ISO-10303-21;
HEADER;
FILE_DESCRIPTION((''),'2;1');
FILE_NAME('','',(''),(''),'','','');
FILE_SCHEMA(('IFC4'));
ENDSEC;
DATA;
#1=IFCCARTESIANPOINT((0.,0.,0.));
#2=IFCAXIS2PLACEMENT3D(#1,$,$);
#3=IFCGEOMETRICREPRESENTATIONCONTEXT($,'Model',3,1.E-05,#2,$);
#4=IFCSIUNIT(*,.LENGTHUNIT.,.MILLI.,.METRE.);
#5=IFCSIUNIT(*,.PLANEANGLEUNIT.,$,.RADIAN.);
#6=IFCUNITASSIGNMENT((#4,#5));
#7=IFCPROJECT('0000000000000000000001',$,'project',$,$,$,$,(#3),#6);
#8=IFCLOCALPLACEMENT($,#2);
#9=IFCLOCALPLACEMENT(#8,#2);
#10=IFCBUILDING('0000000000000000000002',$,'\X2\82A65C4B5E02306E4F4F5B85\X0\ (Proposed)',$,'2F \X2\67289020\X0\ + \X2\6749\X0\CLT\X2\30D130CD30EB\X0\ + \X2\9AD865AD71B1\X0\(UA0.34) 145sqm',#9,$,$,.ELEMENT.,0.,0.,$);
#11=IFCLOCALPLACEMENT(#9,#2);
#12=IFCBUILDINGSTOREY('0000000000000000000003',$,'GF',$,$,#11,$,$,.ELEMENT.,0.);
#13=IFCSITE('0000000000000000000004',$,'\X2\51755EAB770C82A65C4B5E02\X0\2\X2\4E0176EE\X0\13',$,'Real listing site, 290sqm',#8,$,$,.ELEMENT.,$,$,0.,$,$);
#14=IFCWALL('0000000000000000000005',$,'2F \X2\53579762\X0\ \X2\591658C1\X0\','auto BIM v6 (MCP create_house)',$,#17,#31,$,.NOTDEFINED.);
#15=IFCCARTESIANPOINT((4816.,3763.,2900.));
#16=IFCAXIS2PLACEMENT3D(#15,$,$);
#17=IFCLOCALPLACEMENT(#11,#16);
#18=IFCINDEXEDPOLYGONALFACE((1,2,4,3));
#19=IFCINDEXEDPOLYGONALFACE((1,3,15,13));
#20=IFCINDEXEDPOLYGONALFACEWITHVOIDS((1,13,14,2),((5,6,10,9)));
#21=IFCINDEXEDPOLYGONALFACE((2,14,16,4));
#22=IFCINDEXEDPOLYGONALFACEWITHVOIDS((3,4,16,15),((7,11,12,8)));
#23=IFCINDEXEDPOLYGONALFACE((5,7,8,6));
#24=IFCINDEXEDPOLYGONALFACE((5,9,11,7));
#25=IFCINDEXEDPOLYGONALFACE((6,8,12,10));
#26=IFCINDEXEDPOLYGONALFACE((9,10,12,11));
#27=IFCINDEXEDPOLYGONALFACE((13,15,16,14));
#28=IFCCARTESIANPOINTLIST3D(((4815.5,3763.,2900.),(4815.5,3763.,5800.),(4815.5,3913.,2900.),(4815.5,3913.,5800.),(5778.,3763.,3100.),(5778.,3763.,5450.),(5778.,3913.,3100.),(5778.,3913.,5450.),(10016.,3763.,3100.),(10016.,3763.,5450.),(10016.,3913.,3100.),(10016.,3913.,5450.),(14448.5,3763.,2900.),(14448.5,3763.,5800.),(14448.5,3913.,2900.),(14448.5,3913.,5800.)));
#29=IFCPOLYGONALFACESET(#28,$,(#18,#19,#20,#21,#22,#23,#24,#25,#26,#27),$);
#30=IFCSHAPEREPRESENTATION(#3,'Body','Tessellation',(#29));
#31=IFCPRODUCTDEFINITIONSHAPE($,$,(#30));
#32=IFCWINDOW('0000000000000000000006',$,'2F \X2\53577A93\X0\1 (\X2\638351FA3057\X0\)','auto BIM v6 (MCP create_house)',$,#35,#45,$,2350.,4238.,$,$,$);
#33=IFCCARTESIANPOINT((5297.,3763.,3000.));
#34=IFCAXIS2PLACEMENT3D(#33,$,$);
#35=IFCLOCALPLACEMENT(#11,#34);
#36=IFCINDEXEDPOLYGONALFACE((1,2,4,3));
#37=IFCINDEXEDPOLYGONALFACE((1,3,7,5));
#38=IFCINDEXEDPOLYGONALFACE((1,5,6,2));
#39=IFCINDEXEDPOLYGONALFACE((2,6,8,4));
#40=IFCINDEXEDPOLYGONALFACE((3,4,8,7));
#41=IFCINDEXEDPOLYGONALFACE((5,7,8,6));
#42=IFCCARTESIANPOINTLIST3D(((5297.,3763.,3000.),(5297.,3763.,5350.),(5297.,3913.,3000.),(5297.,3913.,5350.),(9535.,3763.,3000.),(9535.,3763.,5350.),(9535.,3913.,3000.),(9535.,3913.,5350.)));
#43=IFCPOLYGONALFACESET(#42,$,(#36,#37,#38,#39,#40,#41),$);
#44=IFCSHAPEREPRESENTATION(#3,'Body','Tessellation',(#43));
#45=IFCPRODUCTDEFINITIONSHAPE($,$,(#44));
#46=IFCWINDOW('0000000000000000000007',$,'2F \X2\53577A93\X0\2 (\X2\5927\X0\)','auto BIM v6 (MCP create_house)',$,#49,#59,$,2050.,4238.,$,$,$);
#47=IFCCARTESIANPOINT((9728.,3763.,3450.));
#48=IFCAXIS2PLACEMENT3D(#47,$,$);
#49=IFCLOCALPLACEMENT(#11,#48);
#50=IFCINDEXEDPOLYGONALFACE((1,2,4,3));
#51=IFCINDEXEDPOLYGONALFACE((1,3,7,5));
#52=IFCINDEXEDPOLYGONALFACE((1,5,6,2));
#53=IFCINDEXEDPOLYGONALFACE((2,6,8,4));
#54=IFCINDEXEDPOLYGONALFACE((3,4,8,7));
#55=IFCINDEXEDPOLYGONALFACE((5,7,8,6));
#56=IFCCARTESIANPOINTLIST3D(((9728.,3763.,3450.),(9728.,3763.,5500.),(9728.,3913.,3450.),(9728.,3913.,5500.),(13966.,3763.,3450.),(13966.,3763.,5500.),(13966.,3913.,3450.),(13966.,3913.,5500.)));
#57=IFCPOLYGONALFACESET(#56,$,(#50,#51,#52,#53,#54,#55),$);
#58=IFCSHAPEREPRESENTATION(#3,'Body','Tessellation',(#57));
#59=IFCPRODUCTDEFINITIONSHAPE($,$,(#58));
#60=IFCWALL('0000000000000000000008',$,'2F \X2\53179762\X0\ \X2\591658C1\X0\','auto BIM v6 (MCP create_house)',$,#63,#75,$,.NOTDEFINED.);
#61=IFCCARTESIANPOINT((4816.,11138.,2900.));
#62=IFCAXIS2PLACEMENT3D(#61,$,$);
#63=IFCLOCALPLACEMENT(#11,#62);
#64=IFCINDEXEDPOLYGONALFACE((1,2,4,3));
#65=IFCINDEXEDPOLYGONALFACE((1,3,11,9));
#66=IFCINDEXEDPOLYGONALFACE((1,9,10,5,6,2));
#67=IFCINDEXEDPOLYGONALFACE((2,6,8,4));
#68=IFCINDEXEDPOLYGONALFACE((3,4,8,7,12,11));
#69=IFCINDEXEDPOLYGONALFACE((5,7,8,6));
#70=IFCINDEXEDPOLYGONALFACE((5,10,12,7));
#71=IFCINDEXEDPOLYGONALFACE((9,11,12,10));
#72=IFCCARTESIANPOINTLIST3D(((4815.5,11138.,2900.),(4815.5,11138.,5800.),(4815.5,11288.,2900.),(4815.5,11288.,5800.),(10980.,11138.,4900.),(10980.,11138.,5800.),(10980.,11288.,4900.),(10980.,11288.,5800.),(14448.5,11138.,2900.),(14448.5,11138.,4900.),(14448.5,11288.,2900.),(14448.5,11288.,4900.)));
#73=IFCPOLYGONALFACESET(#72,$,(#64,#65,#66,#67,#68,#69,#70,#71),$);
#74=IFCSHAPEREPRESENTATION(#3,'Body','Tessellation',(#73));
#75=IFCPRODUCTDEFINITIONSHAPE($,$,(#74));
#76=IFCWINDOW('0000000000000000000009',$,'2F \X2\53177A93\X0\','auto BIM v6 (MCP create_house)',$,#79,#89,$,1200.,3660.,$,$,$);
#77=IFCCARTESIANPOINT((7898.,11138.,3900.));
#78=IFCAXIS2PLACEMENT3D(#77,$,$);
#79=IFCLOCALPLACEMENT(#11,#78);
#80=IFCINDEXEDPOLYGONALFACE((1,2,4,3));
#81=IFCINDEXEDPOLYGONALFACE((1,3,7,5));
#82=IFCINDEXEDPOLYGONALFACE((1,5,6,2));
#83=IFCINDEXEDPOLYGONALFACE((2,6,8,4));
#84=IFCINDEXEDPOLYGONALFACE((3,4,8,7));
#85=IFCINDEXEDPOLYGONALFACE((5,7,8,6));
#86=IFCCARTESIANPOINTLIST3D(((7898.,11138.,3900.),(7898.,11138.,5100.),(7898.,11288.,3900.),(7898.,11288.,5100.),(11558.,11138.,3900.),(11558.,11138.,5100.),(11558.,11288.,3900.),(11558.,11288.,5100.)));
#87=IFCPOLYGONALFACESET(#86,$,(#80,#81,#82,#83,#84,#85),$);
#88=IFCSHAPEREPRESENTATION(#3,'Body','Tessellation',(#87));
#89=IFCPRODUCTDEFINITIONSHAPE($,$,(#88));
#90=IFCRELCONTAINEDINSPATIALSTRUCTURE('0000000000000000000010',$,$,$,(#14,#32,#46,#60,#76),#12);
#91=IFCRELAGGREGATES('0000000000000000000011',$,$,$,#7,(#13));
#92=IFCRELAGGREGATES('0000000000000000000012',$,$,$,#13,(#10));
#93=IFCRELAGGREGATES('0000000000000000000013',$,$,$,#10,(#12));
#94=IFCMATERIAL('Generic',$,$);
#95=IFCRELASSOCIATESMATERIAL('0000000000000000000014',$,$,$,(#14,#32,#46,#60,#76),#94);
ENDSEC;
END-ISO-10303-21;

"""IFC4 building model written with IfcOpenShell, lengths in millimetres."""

from ifc_helpers import new_model, si_unit, frame, frame_2d, origin, place, context, project, spatial, rectangle, extrude, material, element, fill, save


model = new_model("IFC4")

# Units and contexts
model_context = context("Model", 3, precision=1e-05, world=origin())
ifc_project = project(units=[si_unit("LENGTHUNIT", "METRE", prefix="MILLI"), si_unit("PLANEANGLEUNIT", "RADIAN")], contexts=[model_context])

# Site, building, storey
site_placement = place(None, origin())
site = spatial("IfcSite", under=ifc_project, at=site_placement, Name="兵庫県芦屋市2丁目13", ObjectType="Real listing site, 290sqm", CompositionType="ELEMENT", RefElevation=0.0)
building_placement = place(site_placement, origin())
building = spatial("IfcBuilding", under=site, at=building_placement, Name="芦屋市の住宅 (Proposed)", ObjectType="2F 木造 + 杉CLTパネル + 高断熱(UA0.34) 145sqm", CompositionType="ELEMENT", ElevationOfRefHeight=0.0, ElevationOfTerrain=0.0)
storey_placement = place(building_placement, origin())
storey = spatial("IfcBuildingStorey", under=building, at=storey_placement, Name="GF", CompositionType="ELEMENT", Elevation=0.0)

# Shared definitions
ifc_material = material(Name="Generic")

# Wall, openings, windows
wall_1_placement = place(storey_placement, frame((4816.0, 3763.0, 2900.0)))
wall_1 = element("IfcWall", 1, at=wall_1_placement, inside=storey, material=ifc_material, Name="2F 南面 外壁", Description="auto BIM v6 (MCP create_house)", PredefinedType="NOTDEFINED", context=model_context, shape_type="SweptSolid", body=[
    extrude(rectangle(XDim=9633.0, YDim=150.0, at=frame_2d((4816.0, 75.0))), frame((4816.0, 3763.0, 2900.0)), (0.0, 0.0, 1.0), 2900.0),
])
opening_1_placement = place(storey_placement, frame((5297.0, 3763.0, 3000.0)))
opening_1 = element("IfcOpeningElement", 2, at=opening_1_placement, cuts=wall_1, PredefinedType="NOTDEFINED", context=model_context, shape_type="SweptSolid", body=[
    extrude(rectangle(XDim=4238.0, YDim=150.0, at=frame_2d((2119.0, 75.0))), frame((5297.0, 3763.0, 3000.0)), (0.0, 0.0, 1.0), 2350.0),
])
opening_2_placement = place(storey_placement, frame((9728.0, 3763.0, 3450.0)))
opening_2 = element("IfcOpeningElement", 3, at=opening_2_placement, cuts=wall_1, PredefinedType="NOTDEFINED", context=model_context, shape_type="SweptSolid", body=[
    extrude(rectangle(XDim=4238.0, YDim=150.0, at=frame_2d((2119.0, 75.0))), frame((9728.0, 3763.0, 3450.0)), (0.0, 0.0, 1.0), 2050.0),
])
window_1_placement = place(storey_placement, frame((5297.0, 3763.0, 3000.0)))
window_1 = element("IfcWindow", 4, at=window_1_placement, inside=storey, material=ifc_material, Name="2F 南窓1 (掃出し)", Description="auto BIM v6 (MCP create_house)", OverallHeight=2350.0, OverallWidth=4238.0, context=model_context, shape_type="SweptSolid", body=[
    extrude(rectangle(XDim=4238.0, YDim=150.0, at=frame_2d((2119.0, 75.0))), frame((5297.0, 3763.0, 3000.0)), (0.0, 0.0, 1.0), 2350.0),
])
fill(opening_1, window_1)
window_2_placement = place(storey_placement, frame((9728.0, 3763.0, 3450.0)))
window_2 = element("IfcWindow", 5, at=window_2_placement, inside=storey, material=ifc_material, Name="2F 南窓2 (大)", Description="auto BIM v6 (MCP create_house)", OverallHeight=2050.0, OverallWidth=4238.0, context=model_context, shape_type="SweptSolid", body=[
    extrude(rectangle(XDim=4238.0, YDim=150.0, at=frame_2d((2119.0, 75.0))), frame((9728.0, 3763.0, 3450.0)), (0.0, 0.0, 1.0), 2050.0),
])
fill(opening_2, window_2)

# Wall, opening, window
wall_2_placement = place(storey_placement, frame((4816.0, 11138.0, 2900.0)))
wall_2 = element("IfcWall", 6, at=wall_2_placement, inside=storey, material=ifc_material, Name="2F 北面 外壁", Description="auto BIM v6 (MCP create_house)", PredefinedType="NOTDEFINED", context=model_context, shape_type="SweptSolid", body=[
    extrude(rectangle(XDim=9633.0, YDim=150.0, at=frame_2d((4816.0, 75.0))), frame((4816.0, 11138.0, 2900.0)), (0.0, 0.0, 1.0), 2900.0),
])
opening_3_placement = place(storey_placement, frame((7898.0, 11138.0, 3900.0)))
opening_3 = element("IfcOpeningElement", 7, at=opening_3_placement, cuts=wall_2, PredefinedType="NOTDEFINED", context=model_context, shape_type="SweptSolid", body=[
    extrude(rectangle(XDim=3660.0, YDim=150.0, at=frame_2d((1830.0, 75.0))), frame((7898.0, 11138.0, 3900.0)), (0.0, 0.0, 1.0), 1200.0),
])
window_3_placement = place(storey_placement, frame((7898.0, 11138.0, 3900.0)))
window_3 = element("IfcWindow", 8, at=window_3_placement, inside=storey, material=ifc_material, Name="2F 北窓", Description="auto BIM v6 (MCP create_house)", OverallHeight=1200.0, OverallWidth=3660.0, context=model_context, shape_type="SweptSolid", body=[
    extrude(rectangle(XDim=3660.0, YDim=150.0, at=frame_2d((1830.0, 75.0))), frame((7898.0, 11138.0, 3900.0)), (0.0, 0.0, 1.0), 1200.0),
])
fill(opening_3, window_3)

save(model, "model.ifc")
